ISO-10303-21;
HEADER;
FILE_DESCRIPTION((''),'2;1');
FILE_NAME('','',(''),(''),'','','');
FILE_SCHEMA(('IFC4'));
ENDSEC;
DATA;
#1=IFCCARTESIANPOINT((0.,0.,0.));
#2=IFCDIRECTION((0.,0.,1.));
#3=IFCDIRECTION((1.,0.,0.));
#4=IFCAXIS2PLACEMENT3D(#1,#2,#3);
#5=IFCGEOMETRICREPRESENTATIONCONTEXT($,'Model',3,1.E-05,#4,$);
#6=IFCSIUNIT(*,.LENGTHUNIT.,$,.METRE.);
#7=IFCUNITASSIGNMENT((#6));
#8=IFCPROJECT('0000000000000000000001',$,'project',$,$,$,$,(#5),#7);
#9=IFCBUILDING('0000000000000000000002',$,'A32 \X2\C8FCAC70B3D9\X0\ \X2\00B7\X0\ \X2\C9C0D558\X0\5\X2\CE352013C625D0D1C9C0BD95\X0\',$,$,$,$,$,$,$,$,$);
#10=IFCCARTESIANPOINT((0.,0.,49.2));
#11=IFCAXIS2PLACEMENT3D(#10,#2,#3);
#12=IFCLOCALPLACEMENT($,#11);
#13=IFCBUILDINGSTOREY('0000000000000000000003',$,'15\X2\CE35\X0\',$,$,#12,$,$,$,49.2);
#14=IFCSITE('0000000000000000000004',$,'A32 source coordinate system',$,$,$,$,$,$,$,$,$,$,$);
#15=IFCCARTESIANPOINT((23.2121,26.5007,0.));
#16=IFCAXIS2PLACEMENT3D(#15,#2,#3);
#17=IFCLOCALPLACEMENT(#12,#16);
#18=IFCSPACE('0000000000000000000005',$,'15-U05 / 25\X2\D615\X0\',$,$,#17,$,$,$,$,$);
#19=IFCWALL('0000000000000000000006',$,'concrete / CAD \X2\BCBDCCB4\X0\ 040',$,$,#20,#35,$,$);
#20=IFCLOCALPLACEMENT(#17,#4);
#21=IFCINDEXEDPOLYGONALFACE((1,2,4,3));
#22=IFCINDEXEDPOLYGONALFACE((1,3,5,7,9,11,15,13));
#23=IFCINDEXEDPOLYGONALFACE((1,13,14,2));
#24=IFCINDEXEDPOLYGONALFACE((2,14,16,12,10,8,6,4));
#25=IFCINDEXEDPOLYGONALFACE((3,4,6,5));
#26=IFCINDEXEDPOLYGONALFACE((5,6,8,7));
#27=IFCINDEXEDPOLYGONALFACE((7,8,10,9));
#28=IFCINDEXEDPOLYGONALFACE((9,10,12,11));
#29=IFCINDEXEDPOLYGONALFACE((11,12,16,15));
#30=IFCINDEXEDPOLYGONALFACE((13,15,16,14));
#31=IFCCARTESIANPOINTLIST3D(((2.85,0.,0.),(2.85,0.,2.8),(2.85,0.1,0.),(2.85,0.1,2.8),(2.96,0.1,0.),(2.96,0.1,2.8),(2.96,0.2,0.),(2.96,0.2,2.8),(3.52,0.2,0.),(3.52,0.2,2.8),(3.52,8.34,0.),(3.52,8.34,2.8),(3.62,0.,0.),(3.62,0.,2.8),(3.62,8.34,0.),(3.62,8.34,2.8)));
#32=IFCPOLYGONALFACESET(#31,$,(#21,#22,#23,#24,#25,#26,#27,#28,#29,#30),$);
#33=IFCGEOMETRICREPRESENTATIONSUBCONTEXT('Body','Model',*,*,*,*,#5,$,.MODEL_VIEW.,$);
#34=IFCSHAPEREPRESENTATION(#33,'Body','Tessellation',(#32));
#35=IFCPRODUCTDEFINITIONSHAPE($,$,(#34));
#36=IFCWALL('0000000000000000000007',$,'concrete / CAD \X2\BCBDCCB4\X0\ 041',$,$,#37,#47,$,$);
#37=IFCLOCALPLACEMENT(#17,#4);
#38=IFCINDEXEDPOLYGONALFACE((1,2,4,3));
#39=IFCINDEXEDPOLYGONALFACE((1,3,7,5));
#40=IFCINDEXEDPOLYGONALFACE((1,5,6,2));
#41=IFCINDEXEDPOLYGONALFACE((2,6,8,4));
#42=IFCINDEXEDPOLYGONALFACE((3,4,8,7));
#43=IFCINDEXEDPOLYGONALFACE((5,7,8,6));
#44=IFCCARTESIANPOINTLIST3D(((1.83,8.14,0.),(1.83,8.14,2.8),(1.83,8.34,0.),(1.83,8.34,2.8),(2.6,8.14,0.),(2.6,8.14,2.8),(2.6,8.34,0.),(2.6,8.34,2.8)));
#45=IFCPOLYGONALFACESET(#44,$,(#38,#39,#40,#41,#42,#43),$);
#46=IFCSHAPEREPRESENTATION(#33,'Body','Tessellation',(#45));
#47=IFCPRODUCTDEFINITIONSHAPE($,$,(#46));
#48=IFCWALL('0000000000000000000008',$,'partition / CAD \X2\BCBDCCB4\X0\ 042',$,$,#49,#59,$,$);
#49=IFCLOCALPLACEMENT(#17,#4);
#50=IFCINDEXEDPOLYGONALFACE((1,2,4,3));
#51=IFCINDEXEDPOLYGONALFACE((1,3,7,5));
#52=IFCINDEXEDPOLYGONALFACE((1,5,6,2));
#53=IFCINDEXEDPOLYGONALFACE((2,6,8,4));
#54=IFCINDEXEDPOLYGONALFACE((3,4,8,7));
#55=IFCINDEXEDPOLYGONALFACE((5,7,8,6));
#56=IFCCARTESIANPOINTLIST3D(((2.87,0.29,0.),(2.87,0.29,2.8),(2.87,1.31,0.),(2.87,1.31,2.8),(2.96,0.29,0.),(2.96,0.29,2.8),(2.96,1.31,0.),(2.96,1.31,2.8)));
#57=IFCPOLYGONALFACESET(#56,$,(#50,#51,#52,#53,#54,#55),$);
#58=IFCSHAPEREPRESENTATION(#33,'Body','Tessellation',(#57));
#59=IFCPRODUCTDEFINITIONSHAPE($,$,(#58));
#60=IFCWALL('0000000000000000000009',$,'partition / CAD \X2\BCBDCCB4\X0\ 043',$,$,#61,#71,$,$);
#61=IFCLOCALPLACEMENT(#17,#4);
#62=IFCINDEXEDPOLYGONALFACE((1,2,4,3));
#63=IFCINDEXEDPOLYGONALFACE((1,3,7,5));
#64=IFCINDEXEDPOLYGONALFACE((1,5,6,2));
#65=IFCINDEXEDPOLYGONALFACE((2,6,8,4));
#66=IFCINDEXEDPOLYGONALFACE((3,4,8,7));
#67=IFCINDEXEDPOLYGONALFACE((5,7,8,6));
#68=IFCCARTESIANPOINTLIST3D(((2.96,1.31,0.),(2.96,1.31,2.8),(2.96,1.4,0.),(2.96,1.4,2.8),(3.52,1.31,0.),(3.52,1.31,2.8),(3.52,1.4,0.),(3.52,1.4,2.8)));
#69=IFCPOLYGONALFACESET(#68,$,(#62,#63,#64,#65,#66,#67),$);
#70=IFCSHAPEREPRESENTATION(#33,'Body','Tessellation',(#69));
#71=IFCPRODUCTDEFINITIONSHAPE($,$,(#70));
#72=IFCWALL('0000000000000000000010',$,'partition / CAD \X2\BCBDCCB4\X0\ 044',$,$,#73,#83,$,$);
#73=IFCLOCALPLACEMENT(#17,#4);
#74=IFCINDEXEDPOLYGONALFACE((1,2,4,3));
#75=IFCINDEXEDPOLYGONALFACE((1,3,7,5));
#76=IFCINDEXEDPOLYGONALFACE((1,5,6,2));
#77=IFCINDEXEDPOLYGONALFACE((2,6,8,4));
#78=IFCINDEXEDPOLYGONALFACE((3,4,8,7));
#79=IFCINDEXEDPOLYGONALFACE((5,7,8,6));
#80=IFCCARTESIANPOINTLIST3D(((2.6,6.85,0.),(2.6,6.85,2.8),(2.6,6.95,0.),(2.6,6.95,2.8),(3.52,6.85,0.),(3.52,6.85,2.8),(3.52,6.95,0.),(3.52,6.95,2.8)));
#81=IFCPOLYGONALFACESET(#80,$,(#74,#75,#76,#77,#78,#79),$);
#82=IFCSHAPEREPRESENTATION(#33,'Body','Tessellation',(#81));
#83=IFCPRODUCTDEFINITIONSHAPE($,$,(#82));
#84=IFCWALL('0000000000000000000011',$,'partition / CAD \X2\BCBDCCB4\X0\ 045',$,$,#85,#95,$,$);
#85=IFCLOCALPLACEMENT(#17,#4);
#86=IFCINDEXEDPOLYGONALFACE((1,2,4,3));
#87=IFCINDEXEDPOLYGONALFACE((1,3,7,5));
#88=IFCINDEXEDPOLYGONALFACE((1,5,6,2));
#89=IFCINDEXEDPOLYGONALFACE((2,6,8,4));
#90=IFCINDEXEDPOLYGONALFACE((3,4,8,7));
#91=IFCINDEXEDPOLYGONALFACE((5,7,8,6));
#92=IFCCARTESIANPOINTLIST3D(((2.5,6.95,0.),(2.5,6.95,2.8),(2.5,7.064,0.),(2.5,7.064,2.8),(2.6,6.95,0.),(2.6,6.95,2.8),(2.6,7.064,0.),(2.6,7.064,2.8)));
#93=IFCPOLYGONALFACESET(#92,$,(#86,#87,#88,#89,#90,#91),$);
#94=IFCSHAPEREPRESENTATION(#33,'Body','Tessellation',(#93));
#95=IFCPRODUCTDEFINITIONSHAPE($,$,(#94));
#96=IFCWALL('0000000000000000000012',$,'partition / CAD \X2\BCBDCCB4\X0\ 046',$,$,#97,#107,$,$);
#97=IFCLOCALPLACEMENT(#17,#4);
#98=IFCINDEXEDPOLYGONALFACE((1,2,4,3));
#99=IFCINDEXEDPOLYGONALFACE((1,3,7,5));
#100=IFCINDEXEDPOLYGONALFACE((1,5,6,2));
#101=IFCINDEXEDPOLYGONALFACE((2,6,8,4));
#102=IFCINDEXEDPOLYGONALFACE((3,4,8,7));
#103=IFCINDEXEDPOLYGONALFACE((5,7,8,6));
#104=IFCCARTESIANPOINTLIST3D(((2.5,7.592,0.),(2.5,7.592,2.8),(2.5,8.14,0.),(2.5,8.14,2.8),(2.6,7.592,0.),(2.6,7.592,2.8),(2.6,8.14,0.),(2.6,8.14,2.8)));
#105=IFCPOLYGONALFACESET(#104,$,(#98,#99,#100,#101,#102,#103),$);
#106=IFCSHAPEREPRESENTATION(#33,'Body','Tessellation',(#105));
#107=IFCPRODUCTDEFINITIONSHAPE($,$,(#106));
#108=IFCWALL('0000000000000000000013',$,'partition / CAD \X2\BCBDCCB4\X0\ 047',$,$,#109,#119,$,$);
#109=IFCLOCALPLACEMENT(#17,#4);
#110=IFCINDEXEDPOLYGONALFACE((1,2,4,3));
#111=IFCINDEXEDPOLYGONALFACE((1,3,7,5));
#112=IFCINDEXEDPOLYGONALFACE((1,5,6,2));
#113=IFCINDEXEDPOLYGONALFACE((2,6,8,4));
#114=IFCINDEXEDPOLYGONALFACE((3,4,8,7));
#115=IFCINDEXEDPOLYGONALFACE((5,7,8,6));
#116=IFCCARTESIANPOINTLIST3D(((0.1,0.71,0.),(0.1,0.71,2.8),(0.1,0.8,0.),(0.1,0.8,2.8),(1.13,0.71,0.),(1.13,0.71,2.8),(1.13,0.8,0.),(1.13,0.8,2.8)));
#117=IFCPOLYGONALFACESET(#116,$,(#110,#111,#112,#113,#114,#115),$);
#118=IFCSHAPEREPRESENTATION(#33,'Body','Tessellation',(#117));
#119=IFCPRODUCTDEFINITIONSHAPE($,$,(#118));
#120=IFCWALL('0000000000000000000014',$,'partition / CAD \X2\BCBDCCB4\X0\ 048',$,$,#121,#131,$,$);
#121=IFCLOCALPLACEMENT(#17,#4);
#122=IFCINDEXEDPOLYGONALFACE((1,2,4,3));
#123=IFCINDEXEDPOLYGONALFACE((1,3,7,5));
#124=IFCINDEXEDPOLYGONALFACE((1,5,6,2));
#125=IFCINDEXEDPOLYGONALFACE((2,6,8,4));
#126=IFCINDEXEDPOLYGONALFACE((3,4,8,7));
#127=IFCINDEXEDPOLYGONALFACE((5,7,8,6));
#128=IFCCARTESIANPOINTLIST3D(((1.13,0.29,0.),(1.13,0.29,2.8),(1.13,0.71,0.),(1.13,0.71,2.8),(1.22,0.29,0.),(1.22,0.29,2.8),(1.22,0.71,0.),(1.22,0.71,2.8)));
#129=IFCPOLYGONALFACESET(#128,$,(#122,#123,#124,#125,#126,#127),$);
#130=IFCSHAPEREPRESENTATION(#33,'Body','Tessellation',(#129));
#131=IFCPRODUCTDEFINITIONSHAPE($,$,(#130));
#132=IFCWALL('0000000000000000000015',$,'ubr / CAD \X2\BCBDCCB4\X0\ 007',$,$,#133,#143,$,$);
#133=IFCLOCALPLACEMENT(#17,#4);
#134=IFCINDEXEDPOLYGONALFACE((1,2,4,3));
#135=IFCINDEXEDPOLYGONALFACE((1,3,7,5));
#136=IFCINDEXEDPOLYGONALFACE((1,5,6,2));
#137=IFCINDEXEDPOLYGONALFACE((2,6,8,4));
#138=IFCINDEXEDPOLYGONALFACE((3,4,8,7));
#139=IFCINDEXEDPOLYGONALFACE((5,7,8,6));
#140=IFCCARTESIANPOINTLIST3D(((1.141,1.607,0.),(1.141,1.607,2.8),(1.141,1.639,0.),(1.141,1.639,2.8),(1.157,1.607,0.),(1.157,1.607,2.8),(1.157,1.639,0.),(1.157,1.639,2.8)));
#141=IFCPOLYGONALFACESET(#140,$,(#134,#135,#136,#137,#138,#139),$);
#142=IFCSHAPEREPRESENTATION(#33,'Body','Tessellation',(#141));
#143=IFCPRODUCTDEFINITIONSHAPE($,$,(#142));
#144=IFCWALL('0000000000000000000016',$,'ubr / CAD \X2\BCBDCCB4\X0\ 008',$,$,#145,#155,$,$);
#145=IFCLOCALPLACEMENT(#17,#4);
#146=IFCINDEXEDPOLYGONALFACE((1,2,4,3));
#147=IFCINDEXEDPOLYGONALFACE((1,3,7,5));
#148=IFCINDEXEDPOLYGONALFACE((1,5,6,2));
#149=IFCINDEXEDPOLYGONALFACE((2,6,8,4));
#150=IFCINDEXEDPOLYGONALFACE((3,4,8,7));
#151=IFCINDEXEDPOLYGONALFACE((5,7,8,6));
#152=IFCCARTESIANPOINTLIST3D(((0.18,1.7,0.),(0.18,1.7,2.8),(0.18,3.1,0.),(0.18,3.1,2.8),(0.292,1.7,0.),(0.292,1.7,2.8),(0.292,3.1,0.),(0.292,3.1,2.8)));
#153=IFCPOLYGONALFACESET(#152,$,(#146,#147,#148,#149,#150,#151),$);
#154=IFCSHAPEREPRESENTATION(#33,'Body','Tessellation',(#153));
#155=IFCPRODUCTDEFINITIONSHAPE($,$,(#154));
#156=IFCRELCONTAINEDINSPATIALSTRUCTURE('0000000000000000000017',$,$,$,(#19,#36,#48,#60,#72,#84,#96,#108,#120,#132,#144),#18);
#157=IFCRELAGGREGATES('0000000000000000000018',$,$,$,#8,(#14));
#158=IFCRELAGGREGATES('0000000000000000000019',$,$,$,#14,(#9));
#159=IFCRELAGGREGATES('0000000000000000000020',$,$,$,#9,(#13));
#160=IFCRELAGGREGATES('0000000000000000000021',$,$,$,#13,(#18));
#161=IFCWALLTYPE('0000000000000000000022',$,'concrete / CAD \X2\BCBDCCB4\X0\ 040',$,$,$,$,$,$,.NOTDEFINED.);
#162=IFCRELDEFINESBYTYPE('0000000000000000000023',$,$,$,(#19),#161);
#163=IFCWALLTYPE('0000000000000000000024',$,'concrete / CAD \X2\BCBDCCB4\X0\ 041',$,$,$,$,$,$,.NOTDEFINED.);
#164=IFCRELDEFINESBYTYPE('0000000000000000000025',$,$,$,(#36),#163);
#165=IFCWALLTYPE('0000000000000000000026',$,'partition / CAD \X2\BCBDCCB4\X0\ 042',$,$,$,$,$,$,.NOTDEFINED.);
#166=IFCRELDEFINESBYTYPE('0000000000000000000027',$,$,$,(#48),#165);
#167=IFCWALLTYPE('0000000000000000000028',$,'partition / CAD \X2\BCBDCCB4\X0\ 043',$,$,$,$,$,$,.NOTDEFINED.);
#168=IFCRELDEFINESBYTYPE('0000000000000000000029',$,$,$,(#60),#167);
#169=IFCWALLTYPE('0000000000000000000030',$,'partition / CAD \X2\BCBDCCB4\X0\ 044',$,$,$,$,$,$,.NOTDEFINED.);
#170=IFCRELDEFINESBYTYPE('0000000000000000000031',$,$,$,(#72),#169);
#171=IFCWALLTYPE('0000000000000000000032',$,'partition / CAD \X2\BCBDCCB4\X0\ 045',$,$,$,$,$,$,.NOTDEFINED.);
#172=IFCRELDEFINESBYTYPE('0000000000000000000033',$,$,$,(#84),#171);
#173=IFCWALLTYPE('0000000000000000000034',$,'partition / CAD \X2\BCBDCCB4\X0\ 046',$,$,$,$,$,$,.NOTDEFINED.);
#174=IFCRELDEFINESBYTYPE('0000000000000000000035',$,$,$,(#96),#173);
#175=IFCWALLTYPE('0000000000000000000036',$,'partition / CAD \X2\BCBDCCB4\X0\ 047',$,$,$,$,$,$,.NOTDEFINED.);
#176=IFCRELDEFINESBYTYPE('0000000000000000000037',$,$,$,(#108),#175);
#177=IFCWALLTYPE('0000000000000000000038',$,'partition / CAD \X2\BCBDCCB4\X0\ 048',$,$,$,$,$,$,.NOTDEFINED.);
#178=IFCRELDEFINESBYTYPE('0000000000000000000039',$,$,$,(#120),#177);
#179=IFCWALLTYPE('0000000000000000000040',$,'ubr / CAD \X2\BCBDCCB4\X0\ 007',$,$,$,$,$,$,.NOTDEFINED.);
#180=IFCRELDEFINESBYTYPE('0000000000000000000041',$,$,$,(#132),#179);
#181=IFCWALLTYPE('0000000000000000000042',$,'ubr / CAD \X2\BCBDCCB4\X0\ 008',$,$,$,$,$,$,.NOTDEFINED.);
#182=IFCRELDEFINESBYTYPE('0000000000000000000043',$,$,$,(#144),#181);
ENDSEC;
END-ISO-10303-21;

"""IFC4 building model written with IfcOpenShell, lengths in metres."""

from ifc_helpers import new_model, si_unit, frame, origin, origin_with_axes, place, context, subcontext, project, spatial, polyline, outline, extrude, source, transform, mapped, type_object, type_shapes, element, save


model = new_model("IFC4")

# Units and contexts
model_context = context("Model", 3, precision=1e-05, world=origin_with_axes())
body_context = subcontext(model_context, "Body", "Model", "MODEL_VIEW")
ifc_project = project(units=[si_unit("LENGTHUNIT", "METRE")], contexts=[model_context])

# Site, building, storey, space
site = spatial("IfcSite", under=ifc_project, Name="A32 source coordinate system")
building = spatial("IfcBuilding", under=site, Name="A32 주거동 · 지하5층–옥탑지붕")
storey_placement = place(None, frame((0.0, 0.0, 49.2), z_axis=(0.0, 0.0, 1.0), x_axis=(1.0, 0.0, 0.0)))
storey = spatial("IfcBuildingStorey", under=building, at=storey_placement, Name="15층", Elevation=49.2)
space_1_placement = place(storey_placement, frame((23.2121, 26.5007, 0.0), z_axis=(0.0, 0.0, 1.0), x_axis=(1.0, 0.0, 0.0)))
space_1 = spatial("IfcSpace", under=storey, at=space_1_placement, Name="15-U05 / 25형")

# Walls
wall_type_1 = type_object("IfcWallType", Name="concrete / CAD 벽체 040", PredefinedType="NOTDEFINED")
shared_shape_1 = source(origin(), body_context, "Body", "SweptSolid", [
    extrude(outline(polyline([(3.62, 8.34), (3.62, 0.0), (2.85, 0.0), (2.85, 0.1), (2.96, 0.1), (2.96, 0.2), (3.52, 0.2), (3.52, 8.34), (3.62, 8.34)])), origin(), (0.0, 0.0, 1.0), 2.8),
])
type_shapes(wall_type_1, [shared_shape_1])
wall_1_placement = place(space_1_placement, origin_with_axes())
element("IfcWall", 1, at=wall_1_placement, inside=space_1, type_object=wall_type_1, Name="concrete / CAD 벽체 040", context=body_context, shape_type="MappedRepresentation", body=[
    mapped(shared_shape_1, transform((0.0, 0.0, 0.0), scale=1.0)),
])
wall_type_2 = type_object("IfcWallType", Name="concrete / CAD 벽체 041", PredefinedType="NOTDEFINED")
shared_shape_2 = source(origin(), body_context, "Body", "SweptSolid", [
    extrude(outline(polyline([(2.6, 8.14), (1.83, 8.14), (1.83, 8.34), (2.6, 8.34), (2.6, 8.14)])), origin(), (0.0, 0.0, 1.0), 2.8),
])
type_shapes(wall_type_2, [shared_shape_2])
wall_2_placement = place(space_1_placement, origin_with_axes())
element("IfcWall", 2, at=wall_2_placement, inside=space_1, type_object=wall_type_2, Name="concrete / CAD 벽체 041", context=body_context, shape_type="MappedRepresentation", body=[
    mapped(shared_shape_2, transform((0.0, 0.0, 0.0), scale=1.0)),
])
wall_type_3 = type_object("IfcWallType", Name="partition / CAD 벽체 042", PredefinedType="NOTDEFINED")
shared_shape_3 = source(origin(), body_context, "Body", "SweptSolid", [
    extrude(outline(polyline([(2.87, 1.31), (2.96, 1.31), (2.96, 0.29), (2.87, 0.29), (2.87, 1.31)])), origin(), (0.0, 0.0, 1.0), 2.8),
])
type_shapes(wall_type_3, [shared_shape_3])
wall_3_placement = place(space_1_placement, origin_with_axes())
element("IfcWall", 3, at=wall_3_placement, inside=space_1, type_object=wall_type_3, Name="partition / CAD 벽체 042", context=body_context, shape_type="MappedRepresentation", body=[
    mapped(shared_shape_3, transform((0.0, 0.0, 0.0), scale=1.0)),
])
wall_type_4 = type_object("IfcWallType", Name="partition / CAD 벽체 043", PredefinedType="NOTDEFINED")
shared_shape_4 = source(origin(), body_context, "Body", "SweptSolid", [
    extrude(outline(polyline([(3.52, 1.4), (3.52, 1.31), (2.96, 1.31), (2.96, 1.4), (3.52, 1.4)])), origin(), (0.0, 0.0, 1.0), 2.8),
])
type_shapes(wall_type_4, [shared_shape_4])
wall_4_placement = place(space_1_placement, origin_with_axes())
element("IfcWall", 4, at=wall_4_placement, inside=space_1, type_object=wall_type_4, Name="partition / CAD 벽체 043", context=body_context, shape_type="MappedRepresentation", body=[
    mapped(shared_shape_4, transform((0.0, 0.0, 0.0), scale=1.0)),
])
wall_type_5 = type_object("IfcWallType", Name="partition / CAD 벽체 044", PredefinedType="NOTDEFINED")
shared_shape_5 = source(origin(), body_context, "Body", "SweptSolid", [
    extrude(outline(polyline([(3.52, 6.95), (3.52, 6.85), (2.6, 6.85), (2.6, 6.95), (3.52, 6.95)])), origin(), (0.0, 0.0, 1.0), 2.8),
])
type_shapes(wall_type_5, [shared_shape_5])
wall_5_placement = place(space_1_placement, origin_with_axes())
element("IfcWall", 5, at=wall_5_placement, inside=space_1, type_object=wall_type_5, Name="partition / CAD 벽체 044", context=body_context, shape_type="MappedRepresentation", body=[
    mapped(shared_shape_5, transform((0.0, 0.0, 0.0), scale=1.0)),
])
wall_type_6 = type_object("IfcWallType", Name="partition / CAD 벽체 045", PredefinedType="NOTDEFINED")
shared_shape_6 = source(origin(), body_context, "Body", "SweptSolid", [
    extrude(outline(polyline([(2.5, 7.064), (2.6, 7.064), (2.6, 6.95), (2.5, 6.95), (2.5, 7.064)])), origin(), (0.0, 0.0, 1.0), 2.8),
])
type_shapes(wall_type_6, [shared_shape_6])
wall_6_placement = place(space_1_placement, origin_with_axes())
element("IfcWall", 6, at=wall_6_placement, inside=space_1, type_object=wall_type_6, Name="partition / CAD 벽체 045", context=body_context, shape_type="MappedRepresentation", body=[
    mapped(shared_shape_6, transform((0.0, 0.0, 0.0), scale=1.0)),
])
wall_type_7 = type_object("IfcWallType", Name="partition / CAD 벽체 046", PredefinedType="NOTDEFINED")
shared_shape_7 = source(origin(), body_context, "Body", "SweptSolid", [
    extrude(outline(polyline([(2.6, 7.592), (2.5, 7.592), (2.5, 8.14), (2.6, 8.14), (2.6, 7.592)])), origin(), (0.0, 0.0, 1.0), 2.8),
])
type_shapes(wall_type_7, [shared_shape_7])
wall_7_placement = place(space_1_placement, origin_with_axes())
element("IfcWall", 7, at=wall_7_placement, inside=space_1, type_object=wall_type_7, Name="partition / CAD 벽체 046", context=body_context, shape_type="MappedRepresentation", body=[
    mapped(shared_shape_7, transform((0.0, 0.0, 0.0), scale=1.0)),
])
wall_type_8 = type_object("IfcWallType", Name="partition / CAD 벽체 047", PredefinedType="NOTDEFINED")
shared_shape_8 = source(origin(), body_context, "Body", "SweptSolid", [
    extrude(outline(polyline([(1.13, 0.71), (0.1, 0.71), (0.1, 0.8), (1.13, 0.8), (1.13, 0.71)])), origin(), (0.0, 0.0, 1.0), 2.8),
])
type_shapes(wall_type_8, [shared_shape_8])
wall_8_placement = place(space_1_placement, origin_with_axes())
element("IfcWall", 8, at=wall_8_placement, inside=space_1, type_object=wall_type_8, Name="partition / CAD 벽체 047", context=body_context, shape_type="MappedRepresentation", body=[
    mapped(shared_shape_8, transform((0.0, 0.0, 0.0), scale=1.0)),
])
wall_type_9 = type_object("IfcWallType", Name="partition / CAD 벽체 048", PredefinedType="NOTDEFINED")
shared_shape_9 = source(origin(), body_context, "Body", "SweptSolid", [
    extrude(outline(polyline([(1.22, 0.29), (1.13, 0.29), (1.13, 0.71), (1.22, 0.71), (1.22, 0.29)])), origin(), (0.0, 0.0, 1.0), 2.8),
])
type_shapes(wall_type_9, [shared_shape_9])
wall_9_placement = place(space_1_placement, origin_with_axes())
element("IfcWall", 9, at=wall_9_placement, inside=space_1, type_object=wall_type_9, Name="partition / CAD 벽체 048", context=body_context, shape_type="MappedRepresentation", body=[
    mapped(shared_shape_9, transform((0.0, 0.0, 0.0), scale=1.0)),
])
wall_type_10 = type_object("IfcWallType", Name="ubr / CAD 벽체 007", PredefinedType="NOTDEFINED")
shared_shape_10 = source(origin(), body_context, "Body", "SweptSolid", [
    extrude(outline(polyline([(1.157, 1.607), (1.141, 1.607), (1.141, 1.639), (1.157, 1.639), (1.157, 1.607)])), origin(), (0.0, 0.0, 1.0), 2.8),
])
type_shapes(wall_type_10, [shared_shape_10])
wall_10_placement = place(space_1_placement, origin_with_axes())
element("IfcWall", 10, at=wall_10_placement, inside=space_1, type_object=wall_type_10, Name="ubr / CAD 벽체 007", context=body_context, shape_type="MappedRepresentation", body=[
    mapped(shared_shape_10, transform((0.0, 0.0, 0.0), scale=1.0)),
])
wall_type_11 = type_object("IfcWallType", Name="ubr / CAD 벽체 008", PredefinedType="NOTDEFINED")
shared_shape_11 = source(origin(), body_context, "Body", "SweptSolid", [
    extrude(outline(polyline([(0.292, 1.7), (0.18, 1.7), (0.18, 3.1), (0.292, 3.1), (0.292, 1.7)])), origin(), (0.0, 0.0, 1.0), 2.8),
])
type_shapes(wall_type_11, [shared_shape_11])
wall_11_placement = place(space_1_placement, origin_with_axes())
element("IfcWall", 11, at=wall_11_placement, inside=space_1, type_object=wall_type_11, Name="ubr / CAD 벽체 008", context=body_context, shape_type="MappedRepresentation", body=[
    mapped(shared_shape_11, transform((0.0, 0.0, 0.0), scale=1.0)),
])

save(model, "model.ifc")
